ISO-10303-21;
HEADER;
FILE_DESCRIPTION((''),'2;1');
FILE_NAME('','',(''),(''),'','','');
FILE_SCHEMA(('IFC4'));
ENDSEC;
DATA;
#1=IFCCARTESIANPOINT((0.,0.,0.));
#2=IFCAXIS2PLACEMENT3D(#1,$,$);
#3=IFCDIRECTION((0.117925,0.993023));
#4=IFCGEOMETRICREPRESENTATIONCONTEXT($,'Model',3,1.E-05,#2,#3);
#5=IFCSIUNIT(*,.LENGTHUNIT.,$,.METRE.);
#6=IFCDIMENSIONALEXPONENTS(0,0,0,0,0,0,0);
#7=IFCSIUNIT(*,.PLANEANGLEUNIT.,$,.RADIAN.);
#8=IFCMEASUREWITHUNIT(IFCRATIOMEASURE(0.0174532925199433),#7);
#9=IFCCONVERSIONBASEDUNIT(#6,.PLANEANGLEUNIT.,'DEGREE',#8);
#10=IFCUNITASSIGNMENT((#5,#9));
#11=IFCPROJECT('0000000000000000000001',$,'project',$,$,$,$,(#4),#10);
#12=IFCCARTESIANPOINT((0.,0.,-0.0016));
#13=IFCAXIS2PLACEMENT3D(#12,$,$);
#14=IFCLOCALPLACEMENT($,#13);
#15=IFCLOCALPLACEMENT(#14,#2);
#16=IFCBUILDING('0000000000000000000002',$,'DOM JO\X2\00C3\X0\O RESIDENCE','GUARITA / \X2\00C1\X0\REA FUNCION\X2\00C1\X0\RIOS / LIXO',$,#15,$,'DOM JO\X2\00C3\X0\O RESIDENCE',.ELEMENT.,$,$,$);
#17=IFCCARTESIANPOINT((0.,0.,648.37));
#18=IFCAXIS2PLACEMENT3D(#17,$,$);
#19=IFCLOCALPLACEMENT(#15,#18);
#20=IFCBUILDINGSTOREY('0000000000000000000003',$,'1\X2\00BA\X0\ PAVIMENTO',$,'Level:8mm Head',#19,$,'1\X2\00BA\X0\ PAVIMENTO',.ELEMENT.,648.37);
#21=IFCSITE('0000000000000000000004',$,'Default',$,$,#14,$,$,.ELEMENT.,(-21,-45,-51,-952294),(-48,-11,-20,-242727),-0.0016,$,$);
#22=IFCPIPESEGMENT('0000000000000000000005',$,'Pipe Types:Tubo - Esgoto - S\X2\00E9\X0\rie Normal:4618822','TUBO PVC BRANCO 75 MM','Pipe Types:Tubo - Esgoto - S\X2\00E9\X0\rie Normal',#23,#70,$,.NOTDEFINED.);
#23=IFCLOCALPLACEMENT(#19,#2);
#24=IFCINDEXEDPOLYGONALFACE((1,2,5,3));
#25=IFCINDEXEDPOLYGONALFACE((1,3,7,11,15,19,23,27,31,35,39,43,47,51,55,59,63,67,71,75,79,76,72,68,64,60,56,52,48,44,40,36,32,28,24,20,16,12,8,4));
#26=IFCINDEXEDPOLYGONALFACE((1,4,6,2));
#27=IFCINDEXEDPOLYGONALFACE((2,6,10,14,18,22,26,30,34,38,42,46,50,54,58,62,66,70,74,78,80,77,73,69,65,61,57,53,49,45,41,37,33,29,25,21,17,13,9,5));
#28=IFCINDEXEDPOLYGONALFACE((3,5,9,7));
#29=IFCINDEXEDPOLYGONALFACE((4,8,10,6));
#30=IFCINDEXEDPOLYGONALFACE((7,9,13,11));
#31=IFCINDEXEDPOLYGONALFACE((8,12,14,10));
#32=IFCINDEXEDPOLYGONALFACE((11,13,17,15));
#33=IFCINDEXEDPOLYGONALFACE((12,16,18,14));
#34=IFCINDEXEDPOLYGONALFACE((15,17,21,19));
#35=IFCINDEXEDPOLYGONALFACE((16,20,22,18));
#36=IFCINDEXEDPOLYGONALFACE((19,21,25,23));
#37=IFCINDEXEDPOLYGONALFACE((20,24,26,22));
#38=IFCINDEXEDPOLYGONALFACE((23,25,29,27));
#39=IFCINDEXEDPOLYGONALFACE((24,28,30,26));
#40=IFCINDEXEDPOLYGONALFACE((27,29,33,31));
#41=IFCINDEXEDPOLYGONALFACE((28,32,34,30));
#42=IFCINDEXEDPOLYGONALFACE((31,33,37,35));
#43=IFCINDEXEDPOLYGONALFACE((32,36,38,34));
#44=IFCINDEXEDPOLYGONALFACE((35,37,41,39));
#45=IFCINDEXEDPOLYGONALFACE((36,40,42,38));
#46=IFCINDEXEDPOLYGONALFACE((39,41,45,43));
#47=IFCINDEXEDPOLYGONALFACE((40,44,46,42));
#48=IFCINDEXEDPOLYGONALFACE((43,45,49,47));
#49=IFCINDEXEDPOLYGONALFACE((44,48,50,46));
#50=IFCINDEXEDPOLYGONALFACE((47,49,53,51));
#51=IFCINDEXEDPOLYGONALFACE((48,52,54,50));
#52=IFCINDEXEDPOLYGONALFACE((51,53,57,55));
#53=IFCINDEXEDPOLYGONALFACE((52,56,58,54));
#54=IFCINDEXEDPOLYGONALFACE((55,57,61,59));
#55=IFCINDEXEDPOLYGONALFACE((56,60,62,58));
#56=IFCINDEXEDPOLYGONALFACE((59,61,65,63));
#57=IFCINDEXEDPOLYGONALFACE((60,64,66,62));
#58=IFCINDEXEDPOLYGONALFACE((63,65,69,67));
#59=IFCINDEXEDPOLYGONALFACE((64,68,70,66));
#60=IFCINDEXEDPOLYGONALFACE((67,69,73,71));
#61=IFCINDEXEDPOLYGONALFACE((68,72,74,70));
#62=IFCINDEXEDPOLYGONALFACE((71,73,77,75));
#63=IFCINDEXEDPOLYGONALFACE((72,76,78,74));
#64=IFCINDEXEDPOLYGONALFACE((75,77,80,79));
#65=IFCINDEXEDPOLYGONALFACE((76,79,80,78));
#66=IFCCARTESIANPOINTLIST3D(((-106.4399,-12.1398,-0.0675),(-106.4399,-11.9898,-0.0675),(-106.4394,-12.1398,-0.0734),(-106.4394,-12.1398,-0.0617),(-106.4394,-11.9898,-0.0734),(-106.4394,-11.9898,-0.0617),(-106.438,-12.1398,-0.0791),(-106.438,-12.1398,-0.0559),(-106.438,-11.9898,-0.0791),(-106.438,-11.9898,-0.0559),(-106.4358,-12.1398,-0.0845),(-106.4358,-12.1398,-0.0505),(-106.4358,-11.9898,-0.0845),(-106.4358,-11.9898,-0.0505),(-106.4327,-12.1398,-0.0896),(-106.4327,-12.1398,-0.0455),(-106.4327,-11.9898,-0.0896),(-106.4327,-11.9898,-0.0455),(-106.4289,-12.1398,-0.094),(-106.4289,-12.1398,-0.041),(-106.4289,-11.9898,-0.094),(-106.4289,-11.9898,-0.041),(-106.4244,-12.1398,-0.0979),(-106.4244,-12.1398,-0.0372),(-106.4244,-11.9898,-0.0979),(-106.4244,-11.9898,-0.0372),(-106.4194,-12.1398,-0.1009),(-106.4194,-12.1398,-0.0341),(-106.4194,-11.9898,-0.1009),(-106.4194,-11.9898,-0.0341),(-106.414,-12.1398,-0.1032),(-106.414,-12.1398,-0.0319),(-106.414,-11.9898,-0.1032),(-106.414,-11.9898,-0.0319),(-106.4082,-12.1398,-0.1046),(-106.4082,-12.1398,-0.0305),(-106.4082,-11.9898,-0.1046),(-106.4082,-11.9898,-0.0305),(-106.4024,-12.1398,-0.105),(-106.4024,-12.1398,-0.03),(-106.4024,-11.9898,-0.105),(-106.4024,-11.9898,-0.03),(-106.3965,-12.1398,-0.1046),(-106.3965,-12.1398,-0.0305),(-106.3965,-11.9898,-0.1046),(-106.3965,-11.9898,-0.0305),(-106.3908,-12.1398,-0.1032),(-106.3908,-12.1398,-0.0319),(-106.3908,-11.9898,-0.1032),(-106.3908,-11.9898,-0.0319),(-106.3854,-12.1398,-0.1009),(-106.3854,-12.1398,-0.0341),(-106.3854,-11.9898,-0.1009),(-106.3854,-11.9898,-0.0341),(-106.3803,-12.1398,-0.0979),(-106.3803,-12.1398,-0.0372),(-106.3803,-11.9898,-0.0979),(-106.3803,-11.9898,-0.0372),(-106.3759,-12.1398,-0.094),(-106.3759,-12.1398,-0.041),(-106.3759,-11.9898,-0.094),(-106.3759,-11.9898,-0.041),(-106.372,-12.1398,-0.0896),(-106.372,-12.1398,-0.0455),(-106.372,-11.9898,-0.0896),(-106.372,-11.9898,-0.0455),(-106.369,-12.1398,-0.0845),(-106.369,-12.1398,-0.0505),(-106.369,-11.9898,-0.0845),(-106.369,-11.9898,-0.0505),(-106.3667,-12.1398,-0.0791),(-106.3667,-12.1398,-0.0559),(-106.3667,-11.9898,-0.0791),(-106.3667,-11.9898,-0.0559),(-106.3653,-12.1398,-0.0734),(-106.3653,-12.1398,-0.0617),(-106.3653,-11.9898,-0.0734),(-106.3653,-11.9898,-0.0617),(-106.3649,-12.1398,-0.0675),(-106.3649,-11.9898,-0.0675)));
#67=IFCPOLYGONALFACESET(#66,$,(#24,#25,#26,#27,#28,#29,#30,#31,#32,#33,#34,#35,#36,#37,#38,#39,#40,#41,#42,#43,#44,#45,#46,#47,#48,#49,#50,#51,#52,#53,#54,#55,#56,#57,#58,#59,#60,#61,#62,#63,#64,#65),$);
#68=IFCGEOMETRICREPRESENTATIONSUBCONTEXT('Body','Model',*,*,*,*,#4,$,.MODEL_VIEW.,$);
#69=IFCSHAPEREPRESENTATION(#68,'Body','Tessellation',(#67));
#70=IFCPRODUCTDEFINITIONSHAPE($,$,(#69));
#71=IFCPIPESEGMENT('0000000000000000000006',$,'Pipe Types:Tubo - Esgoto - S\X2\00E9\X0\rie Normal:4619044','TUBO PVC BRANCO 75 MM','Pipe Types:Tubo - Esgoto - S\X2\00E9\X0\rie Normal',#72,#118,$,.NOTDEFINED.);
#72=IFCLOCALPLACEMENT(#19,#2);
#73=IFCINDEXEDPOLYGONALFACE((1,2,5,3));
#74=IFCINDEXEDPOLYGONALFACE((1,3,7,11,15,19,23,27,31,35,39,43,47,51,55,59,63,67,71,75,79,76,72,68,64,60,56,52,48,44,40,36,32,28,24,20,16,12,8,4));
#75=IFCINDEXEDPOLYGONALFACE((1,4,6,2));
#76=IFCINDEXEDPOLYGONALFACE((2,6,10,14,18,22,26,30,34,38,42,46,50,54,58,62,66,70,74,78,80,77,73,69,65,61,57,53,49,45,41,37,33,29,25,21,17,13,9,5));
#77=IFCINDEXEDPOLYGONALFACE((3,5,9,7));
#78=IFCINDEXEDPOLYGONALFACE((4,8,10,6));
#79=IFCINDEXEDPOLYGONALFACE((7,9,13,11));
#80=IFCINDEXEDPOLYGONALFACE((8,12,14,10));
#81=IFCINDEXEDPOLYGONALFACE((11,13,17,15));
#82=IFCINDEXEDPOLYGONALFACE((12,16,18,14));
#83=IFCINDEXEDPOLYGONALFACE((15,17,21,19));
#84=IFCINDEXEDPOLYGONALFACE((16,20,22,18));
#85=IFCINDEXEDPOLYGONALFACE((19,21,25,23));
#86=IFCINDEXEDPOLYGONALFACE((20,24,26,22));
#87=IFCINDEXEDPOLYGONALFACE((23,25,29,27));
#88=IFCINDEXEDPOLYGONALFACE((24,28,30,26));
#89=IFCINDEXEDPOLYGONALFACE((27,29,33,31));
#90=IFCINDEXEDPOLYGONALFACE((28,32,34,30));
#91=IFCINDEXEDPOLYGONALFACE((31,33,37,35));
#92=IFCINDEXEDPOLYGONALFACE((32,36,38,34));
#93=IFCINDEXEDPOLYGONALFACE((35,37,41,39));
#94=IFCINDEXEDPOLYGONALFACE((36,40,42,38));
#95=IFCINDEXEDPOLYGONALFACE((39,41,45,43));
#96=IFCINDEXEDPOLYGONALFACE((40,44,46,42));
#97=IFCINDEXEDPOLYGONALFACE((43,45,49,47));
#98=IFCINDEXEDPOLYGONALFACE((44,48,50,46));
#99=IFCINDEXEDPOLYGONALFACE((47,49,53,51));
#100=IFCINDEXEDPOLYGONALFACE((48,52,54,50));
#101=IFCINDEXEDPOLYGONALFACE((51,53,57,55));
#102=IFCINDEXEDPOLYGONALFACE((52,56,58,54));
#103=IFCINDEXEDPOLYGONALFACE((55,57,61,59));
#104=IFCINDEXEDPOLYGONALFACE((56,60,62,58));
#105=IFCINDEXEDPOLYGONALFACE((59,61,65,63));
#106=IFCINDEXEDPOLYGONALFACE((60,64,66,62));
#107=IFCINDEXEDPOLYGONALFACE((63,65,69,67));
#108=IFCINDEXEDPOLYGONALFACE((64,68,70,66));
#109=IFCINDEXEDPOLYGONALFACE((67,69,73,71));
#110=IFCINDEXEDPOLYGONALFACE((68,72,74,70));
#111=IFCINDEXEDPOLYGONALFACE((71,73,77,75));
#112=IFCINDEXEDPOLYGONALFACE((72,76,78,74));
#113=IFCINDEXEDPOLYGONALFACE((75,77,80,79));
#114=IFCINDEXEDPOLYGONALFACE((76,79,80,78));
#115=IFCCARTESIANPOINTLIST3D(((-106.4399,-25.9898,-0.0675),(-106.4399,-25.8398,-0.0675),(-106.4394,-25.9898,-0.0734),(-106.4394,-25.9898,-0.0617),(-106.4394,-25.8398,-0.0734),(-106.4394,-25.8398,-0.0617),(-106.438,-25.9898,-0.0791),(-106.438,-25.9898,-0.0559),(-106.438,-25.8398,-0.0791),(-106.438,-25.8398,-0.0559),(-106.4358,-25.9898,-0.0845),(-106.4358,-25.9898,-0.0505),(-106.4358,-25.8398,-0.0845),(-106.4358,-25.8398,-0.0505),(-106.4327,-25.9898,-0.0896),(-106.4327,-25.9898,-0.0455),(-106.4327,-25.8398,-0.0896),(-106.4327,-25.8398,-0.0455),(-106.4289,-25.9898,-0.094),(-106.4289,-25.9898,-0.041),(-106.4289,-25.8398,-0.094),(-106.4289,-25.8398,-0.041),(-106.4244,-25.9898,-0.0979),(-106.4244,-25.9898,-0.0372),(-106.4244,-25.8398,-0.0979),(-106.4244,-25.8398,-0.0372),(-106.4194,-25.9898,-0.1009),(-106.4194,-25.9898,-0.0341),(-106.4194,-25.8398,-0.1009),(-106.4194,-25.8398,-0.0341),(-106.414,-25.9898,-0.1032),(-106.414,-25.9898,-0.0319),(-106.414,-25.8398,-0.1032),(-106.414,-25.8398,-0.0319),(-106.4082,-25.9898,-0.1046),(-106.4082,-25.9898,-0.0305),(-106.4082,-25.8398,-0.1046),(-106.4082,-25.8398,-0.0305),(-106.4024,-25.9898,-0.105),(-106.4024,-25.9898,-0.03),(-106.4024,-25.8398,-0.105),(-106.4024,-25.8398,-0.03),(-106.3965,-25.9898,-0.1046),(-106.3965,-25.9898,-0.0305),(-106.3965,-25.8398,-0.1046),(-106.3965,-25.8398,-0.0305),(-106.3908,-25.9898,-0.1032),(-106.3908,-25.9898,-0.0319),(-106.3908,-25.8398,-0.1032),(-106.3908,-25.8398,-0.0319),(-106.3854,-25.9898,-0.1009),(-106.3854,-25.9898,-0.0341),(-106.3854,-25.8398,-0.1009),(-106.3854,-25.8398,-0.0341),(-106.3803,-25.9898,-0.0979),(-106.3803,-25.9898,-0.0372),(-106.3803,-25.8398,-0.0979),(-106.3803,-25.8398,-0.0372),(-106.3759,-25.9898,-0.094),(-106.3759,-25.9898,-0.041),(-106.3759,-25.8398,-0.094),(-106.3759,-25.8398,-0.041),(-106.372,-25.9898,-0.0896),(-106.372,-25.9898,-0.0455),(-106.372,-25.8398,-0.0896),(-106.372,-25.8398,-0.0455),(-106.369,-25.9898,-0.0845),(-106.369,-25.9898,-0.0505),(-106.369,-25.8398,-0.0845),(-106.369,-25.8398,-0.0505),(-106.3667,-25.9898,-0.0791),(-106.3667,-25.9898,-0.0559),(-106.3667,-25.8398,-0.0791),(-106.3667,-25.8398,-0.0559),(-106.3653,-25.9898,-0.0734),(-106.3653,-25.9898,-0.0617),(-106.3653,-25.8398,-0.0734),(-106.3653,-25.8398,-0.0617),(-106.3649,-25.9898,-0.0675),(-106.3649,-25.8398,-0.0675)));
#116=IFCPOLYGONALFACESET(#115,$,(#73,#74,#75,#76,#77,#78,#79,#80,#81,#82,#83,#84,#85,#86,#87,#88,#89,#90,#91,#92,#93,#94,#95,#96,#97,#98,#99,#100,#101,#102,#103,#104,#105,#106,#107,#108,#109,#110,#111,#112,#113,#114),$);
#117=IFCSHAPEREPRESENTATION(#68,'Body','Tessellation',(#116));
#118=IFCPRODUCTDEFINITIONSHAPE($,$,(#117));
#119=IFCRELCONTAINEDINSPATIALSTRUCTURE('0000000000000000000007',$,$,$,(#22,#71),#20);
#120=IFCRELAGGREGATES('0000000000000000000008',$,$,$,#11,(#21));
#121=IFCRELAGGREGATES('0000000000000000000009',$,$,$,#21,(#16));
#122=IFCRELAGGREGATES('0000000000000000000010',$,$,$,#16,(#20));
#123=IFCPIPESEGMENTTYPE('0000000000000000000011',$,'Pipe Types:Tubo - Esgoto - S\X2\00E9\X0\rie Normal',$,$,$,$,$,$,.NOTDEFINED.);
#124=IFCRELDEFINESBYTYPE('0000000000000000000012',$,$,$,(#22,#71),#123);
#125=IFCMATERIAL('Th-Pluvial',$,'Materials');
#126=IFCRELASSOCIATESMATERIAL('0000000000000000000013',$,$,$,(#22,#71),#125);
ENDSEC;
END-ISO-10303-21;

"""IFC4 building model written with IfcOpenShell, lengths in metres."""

from ifc_helpers import new_model, entity, si_unit, converted_unit, direction, frame, origin, place, context, subcontext, project, spatial, indexed_curve, outline, extrude, material, type_object, element, save


model = new_model("IFC4")

# Units and contexts
model_context = context("Model", 3, precision=1e-05, world=origin(), true_north=direction((0.117925, 0.993023)))
body_context = subcontext(model_context, "Body", "Model", "MODEL_VIEW")
ifc_project = project(units=[si_unit("LENGTHUNIT", "METRE"), converted_unit("PLANEANGLEUNIT", "DEGREE", entity("IfcRatioMeasure", 0.0174532925199433), si_unit("PLANEANGLEUNIT", "RADIAN"), dimensions=[0, 0, 0, 0, 0, 0, 0])], contexts=[model_context])

# Site, building, storey
site_placement = place(None, frame((0.0, 0.0, -0.0016)))
site = spatial("IfcSite", under=ifc_project, at=site_placement, Name="Default", CompositionType="ELEMENT", RefLatitude=(-21, -45, -51, -952294), RefLongitude=(-48, -11, -20, -242727), RefElevation=-0.0016)
building_placement = place(site_placement, origin())
building = spatial("IfcBuilding", under=site, at=building_placement, Name="DOM JOÃO RESIDENCE", Description="GUARITA / ÁREA FUNCIONÁRIOS / LIXO", LongName="DOM JOÃO RESIDENCE", CompositionType="ELEMENT")
storey_placement = place(building_placement, frame((0.0, 0.0, 648.37)))
storey = spatial("IfcBuildingStorey", under=building, at=storey_placement, Name="1º PAVIMENTO", ObjectType="Level:8mm Head", LongName="1º PAVIMENTO", CompositionType="ELEMENT", Elevation=648.37)

# Pipe segments
ifc_material = material(Name="Th-Pluvial", Category="Materials")
pipe_segment_type = type_object("IfcPipeSegmentType", Name="Pipe Types:Tubo - Esgoto - Série Normal", PredefinedType="NOTDEFINED")
pipe_segment_1_placement = place(storey_placement, frame((-106.4415, -12.1398, -0.1066)))
element("IfcPipeSegment", 1, at=pipe_segment_1_placement, inside=storey, type_object=pipe_segment_type, material=ifc_material, Name="Pipe Types:Tubo - Esgoto - Série Normal:4618822", Description="TUBO PVC BRANCO 75 MM", ObjectType="Pipe Types:Tubo - Esgoto - Série Normal", PredefinedType="NOTDEFINED", context=body_context, shape_type="SweptSolid", body=[
    extrude(outline(indexed_curve([(0.0375, 0.0), (0.037, 0.0059), (0.0357, 0.0116), (0.0334, 0.017), (0.0303, 0.022), (0.0265, 0.0265), (0.022, 0.0303), (0.017, 0.0334), (0.0116, 0.0357), (0.0059, 0.037), (0.0, 0.0375), (-0.0059, 0.037), (-0.0116, 0.0357), (-0.017, 0.0334), (-0.022, 0.0303), (-0.0265, 0.0265), (-0.0303, 0.022), (-0.0334, 0.017), (-0.0357, 0.0116), (-0.037, 0.0059), (-0.0375, 0.0), (-0.037, -0.0059), (-0.0357, -0.0116), (-0.0334, -0.017), (-0.0303, -0.022), (-0.0265, -0.0265), (-0.022, -0.0303), (-0.017, -0.0334), (-0.0116, -0.0357), (-0.0059, -0.037), (0.0, -0.0375), (0.0059, -0.037), (0.0116, -0.0357), (0.017, -0.0334), (0.022, -0.0303), (0.0265, -0.0265), (0.0303, -0.022), (0.0334, -0.017), (0.0357, -0.0116), (0.037, -0.0059), (0.0375, 0.0)], self_intersect=False)), frame((0.0391, 0.0, 0.0391), z_axis=(0.0, 1.0, 0.0), x_axis=(-1.0, 0.0, 0.0)), (0.0, 0.0, 1.0), 0.15),
])
pipe_segment_2_placement = place(storey_placement, frame((-106.4415, -25.9898, -0.1066)))
element("IfcPipeSegment", 2, at=pipe_segment_2_placement, inside=storey, type_object=pipe_segment_type, material=ifc_material, Name="Pipe Types:Tubo - Esgoto - Série Normal:4619044", Description="TUBO PVC BRANCO 75 MM", ObjectType="Pipe Types:Tubo - Esgoto - Série Normal", PredefinedType="NOTDEFINED", context=body_context, shape_type="SweptSolid", body=[
    extrude(outline(indexed_curve([(0.0375, 0.0), (0.037, 0.0059), (0.0357, 0.0116), (0.0334, 0.017), (0.0303, 0.022), (0.0265, 0.0265), (0.022, 0.0303), (0.017, 0.0334), (0.0116, 0.0357), (0.0059, 0.037), (0.0, 0.0375), (-0.0059, 0.037), (-0.0116, 0.0357), (-0.017, 0.0334), (-0.022, 0.0303), (-0.0265, 0.0265), (-0.0303, 0.022), (-0.0334, 0.017), (-0.0357, 0.0116), (-0.037, 0.0059), (-0.0375, 0.0), (-0.037, -0.0059), (-0.0357, -0.0116), (-0.0334, -0.017), (-0.0303, -0.022), (-0.0265, -0.0265), (-0.022, -0.0303), (-0.017, -0.0334), (-0.0116, -0.0357), (-0.0059, -0.037), (0.0, -0.0375), (0.0059, -0.037), (0.0116, -0.0357), (0.017, -0.0334), (0.022, -0.0303), (0.0265, -0.0265), (0.0303, -0.022), (0.0334, -0.017), (0.0357, -0.0116), (0.037, -0.0059), (0.0375, 0.0)], self_intersect=False)), frame((0.0391, 0.0, 0.0391), z_axis=(0.0, 1.0, 0.0), x_axis=(1.0, 0.0, 0.0)), (0.0, 0.0, 1.0), 0.15),
])

save(model, "model.ifc")
